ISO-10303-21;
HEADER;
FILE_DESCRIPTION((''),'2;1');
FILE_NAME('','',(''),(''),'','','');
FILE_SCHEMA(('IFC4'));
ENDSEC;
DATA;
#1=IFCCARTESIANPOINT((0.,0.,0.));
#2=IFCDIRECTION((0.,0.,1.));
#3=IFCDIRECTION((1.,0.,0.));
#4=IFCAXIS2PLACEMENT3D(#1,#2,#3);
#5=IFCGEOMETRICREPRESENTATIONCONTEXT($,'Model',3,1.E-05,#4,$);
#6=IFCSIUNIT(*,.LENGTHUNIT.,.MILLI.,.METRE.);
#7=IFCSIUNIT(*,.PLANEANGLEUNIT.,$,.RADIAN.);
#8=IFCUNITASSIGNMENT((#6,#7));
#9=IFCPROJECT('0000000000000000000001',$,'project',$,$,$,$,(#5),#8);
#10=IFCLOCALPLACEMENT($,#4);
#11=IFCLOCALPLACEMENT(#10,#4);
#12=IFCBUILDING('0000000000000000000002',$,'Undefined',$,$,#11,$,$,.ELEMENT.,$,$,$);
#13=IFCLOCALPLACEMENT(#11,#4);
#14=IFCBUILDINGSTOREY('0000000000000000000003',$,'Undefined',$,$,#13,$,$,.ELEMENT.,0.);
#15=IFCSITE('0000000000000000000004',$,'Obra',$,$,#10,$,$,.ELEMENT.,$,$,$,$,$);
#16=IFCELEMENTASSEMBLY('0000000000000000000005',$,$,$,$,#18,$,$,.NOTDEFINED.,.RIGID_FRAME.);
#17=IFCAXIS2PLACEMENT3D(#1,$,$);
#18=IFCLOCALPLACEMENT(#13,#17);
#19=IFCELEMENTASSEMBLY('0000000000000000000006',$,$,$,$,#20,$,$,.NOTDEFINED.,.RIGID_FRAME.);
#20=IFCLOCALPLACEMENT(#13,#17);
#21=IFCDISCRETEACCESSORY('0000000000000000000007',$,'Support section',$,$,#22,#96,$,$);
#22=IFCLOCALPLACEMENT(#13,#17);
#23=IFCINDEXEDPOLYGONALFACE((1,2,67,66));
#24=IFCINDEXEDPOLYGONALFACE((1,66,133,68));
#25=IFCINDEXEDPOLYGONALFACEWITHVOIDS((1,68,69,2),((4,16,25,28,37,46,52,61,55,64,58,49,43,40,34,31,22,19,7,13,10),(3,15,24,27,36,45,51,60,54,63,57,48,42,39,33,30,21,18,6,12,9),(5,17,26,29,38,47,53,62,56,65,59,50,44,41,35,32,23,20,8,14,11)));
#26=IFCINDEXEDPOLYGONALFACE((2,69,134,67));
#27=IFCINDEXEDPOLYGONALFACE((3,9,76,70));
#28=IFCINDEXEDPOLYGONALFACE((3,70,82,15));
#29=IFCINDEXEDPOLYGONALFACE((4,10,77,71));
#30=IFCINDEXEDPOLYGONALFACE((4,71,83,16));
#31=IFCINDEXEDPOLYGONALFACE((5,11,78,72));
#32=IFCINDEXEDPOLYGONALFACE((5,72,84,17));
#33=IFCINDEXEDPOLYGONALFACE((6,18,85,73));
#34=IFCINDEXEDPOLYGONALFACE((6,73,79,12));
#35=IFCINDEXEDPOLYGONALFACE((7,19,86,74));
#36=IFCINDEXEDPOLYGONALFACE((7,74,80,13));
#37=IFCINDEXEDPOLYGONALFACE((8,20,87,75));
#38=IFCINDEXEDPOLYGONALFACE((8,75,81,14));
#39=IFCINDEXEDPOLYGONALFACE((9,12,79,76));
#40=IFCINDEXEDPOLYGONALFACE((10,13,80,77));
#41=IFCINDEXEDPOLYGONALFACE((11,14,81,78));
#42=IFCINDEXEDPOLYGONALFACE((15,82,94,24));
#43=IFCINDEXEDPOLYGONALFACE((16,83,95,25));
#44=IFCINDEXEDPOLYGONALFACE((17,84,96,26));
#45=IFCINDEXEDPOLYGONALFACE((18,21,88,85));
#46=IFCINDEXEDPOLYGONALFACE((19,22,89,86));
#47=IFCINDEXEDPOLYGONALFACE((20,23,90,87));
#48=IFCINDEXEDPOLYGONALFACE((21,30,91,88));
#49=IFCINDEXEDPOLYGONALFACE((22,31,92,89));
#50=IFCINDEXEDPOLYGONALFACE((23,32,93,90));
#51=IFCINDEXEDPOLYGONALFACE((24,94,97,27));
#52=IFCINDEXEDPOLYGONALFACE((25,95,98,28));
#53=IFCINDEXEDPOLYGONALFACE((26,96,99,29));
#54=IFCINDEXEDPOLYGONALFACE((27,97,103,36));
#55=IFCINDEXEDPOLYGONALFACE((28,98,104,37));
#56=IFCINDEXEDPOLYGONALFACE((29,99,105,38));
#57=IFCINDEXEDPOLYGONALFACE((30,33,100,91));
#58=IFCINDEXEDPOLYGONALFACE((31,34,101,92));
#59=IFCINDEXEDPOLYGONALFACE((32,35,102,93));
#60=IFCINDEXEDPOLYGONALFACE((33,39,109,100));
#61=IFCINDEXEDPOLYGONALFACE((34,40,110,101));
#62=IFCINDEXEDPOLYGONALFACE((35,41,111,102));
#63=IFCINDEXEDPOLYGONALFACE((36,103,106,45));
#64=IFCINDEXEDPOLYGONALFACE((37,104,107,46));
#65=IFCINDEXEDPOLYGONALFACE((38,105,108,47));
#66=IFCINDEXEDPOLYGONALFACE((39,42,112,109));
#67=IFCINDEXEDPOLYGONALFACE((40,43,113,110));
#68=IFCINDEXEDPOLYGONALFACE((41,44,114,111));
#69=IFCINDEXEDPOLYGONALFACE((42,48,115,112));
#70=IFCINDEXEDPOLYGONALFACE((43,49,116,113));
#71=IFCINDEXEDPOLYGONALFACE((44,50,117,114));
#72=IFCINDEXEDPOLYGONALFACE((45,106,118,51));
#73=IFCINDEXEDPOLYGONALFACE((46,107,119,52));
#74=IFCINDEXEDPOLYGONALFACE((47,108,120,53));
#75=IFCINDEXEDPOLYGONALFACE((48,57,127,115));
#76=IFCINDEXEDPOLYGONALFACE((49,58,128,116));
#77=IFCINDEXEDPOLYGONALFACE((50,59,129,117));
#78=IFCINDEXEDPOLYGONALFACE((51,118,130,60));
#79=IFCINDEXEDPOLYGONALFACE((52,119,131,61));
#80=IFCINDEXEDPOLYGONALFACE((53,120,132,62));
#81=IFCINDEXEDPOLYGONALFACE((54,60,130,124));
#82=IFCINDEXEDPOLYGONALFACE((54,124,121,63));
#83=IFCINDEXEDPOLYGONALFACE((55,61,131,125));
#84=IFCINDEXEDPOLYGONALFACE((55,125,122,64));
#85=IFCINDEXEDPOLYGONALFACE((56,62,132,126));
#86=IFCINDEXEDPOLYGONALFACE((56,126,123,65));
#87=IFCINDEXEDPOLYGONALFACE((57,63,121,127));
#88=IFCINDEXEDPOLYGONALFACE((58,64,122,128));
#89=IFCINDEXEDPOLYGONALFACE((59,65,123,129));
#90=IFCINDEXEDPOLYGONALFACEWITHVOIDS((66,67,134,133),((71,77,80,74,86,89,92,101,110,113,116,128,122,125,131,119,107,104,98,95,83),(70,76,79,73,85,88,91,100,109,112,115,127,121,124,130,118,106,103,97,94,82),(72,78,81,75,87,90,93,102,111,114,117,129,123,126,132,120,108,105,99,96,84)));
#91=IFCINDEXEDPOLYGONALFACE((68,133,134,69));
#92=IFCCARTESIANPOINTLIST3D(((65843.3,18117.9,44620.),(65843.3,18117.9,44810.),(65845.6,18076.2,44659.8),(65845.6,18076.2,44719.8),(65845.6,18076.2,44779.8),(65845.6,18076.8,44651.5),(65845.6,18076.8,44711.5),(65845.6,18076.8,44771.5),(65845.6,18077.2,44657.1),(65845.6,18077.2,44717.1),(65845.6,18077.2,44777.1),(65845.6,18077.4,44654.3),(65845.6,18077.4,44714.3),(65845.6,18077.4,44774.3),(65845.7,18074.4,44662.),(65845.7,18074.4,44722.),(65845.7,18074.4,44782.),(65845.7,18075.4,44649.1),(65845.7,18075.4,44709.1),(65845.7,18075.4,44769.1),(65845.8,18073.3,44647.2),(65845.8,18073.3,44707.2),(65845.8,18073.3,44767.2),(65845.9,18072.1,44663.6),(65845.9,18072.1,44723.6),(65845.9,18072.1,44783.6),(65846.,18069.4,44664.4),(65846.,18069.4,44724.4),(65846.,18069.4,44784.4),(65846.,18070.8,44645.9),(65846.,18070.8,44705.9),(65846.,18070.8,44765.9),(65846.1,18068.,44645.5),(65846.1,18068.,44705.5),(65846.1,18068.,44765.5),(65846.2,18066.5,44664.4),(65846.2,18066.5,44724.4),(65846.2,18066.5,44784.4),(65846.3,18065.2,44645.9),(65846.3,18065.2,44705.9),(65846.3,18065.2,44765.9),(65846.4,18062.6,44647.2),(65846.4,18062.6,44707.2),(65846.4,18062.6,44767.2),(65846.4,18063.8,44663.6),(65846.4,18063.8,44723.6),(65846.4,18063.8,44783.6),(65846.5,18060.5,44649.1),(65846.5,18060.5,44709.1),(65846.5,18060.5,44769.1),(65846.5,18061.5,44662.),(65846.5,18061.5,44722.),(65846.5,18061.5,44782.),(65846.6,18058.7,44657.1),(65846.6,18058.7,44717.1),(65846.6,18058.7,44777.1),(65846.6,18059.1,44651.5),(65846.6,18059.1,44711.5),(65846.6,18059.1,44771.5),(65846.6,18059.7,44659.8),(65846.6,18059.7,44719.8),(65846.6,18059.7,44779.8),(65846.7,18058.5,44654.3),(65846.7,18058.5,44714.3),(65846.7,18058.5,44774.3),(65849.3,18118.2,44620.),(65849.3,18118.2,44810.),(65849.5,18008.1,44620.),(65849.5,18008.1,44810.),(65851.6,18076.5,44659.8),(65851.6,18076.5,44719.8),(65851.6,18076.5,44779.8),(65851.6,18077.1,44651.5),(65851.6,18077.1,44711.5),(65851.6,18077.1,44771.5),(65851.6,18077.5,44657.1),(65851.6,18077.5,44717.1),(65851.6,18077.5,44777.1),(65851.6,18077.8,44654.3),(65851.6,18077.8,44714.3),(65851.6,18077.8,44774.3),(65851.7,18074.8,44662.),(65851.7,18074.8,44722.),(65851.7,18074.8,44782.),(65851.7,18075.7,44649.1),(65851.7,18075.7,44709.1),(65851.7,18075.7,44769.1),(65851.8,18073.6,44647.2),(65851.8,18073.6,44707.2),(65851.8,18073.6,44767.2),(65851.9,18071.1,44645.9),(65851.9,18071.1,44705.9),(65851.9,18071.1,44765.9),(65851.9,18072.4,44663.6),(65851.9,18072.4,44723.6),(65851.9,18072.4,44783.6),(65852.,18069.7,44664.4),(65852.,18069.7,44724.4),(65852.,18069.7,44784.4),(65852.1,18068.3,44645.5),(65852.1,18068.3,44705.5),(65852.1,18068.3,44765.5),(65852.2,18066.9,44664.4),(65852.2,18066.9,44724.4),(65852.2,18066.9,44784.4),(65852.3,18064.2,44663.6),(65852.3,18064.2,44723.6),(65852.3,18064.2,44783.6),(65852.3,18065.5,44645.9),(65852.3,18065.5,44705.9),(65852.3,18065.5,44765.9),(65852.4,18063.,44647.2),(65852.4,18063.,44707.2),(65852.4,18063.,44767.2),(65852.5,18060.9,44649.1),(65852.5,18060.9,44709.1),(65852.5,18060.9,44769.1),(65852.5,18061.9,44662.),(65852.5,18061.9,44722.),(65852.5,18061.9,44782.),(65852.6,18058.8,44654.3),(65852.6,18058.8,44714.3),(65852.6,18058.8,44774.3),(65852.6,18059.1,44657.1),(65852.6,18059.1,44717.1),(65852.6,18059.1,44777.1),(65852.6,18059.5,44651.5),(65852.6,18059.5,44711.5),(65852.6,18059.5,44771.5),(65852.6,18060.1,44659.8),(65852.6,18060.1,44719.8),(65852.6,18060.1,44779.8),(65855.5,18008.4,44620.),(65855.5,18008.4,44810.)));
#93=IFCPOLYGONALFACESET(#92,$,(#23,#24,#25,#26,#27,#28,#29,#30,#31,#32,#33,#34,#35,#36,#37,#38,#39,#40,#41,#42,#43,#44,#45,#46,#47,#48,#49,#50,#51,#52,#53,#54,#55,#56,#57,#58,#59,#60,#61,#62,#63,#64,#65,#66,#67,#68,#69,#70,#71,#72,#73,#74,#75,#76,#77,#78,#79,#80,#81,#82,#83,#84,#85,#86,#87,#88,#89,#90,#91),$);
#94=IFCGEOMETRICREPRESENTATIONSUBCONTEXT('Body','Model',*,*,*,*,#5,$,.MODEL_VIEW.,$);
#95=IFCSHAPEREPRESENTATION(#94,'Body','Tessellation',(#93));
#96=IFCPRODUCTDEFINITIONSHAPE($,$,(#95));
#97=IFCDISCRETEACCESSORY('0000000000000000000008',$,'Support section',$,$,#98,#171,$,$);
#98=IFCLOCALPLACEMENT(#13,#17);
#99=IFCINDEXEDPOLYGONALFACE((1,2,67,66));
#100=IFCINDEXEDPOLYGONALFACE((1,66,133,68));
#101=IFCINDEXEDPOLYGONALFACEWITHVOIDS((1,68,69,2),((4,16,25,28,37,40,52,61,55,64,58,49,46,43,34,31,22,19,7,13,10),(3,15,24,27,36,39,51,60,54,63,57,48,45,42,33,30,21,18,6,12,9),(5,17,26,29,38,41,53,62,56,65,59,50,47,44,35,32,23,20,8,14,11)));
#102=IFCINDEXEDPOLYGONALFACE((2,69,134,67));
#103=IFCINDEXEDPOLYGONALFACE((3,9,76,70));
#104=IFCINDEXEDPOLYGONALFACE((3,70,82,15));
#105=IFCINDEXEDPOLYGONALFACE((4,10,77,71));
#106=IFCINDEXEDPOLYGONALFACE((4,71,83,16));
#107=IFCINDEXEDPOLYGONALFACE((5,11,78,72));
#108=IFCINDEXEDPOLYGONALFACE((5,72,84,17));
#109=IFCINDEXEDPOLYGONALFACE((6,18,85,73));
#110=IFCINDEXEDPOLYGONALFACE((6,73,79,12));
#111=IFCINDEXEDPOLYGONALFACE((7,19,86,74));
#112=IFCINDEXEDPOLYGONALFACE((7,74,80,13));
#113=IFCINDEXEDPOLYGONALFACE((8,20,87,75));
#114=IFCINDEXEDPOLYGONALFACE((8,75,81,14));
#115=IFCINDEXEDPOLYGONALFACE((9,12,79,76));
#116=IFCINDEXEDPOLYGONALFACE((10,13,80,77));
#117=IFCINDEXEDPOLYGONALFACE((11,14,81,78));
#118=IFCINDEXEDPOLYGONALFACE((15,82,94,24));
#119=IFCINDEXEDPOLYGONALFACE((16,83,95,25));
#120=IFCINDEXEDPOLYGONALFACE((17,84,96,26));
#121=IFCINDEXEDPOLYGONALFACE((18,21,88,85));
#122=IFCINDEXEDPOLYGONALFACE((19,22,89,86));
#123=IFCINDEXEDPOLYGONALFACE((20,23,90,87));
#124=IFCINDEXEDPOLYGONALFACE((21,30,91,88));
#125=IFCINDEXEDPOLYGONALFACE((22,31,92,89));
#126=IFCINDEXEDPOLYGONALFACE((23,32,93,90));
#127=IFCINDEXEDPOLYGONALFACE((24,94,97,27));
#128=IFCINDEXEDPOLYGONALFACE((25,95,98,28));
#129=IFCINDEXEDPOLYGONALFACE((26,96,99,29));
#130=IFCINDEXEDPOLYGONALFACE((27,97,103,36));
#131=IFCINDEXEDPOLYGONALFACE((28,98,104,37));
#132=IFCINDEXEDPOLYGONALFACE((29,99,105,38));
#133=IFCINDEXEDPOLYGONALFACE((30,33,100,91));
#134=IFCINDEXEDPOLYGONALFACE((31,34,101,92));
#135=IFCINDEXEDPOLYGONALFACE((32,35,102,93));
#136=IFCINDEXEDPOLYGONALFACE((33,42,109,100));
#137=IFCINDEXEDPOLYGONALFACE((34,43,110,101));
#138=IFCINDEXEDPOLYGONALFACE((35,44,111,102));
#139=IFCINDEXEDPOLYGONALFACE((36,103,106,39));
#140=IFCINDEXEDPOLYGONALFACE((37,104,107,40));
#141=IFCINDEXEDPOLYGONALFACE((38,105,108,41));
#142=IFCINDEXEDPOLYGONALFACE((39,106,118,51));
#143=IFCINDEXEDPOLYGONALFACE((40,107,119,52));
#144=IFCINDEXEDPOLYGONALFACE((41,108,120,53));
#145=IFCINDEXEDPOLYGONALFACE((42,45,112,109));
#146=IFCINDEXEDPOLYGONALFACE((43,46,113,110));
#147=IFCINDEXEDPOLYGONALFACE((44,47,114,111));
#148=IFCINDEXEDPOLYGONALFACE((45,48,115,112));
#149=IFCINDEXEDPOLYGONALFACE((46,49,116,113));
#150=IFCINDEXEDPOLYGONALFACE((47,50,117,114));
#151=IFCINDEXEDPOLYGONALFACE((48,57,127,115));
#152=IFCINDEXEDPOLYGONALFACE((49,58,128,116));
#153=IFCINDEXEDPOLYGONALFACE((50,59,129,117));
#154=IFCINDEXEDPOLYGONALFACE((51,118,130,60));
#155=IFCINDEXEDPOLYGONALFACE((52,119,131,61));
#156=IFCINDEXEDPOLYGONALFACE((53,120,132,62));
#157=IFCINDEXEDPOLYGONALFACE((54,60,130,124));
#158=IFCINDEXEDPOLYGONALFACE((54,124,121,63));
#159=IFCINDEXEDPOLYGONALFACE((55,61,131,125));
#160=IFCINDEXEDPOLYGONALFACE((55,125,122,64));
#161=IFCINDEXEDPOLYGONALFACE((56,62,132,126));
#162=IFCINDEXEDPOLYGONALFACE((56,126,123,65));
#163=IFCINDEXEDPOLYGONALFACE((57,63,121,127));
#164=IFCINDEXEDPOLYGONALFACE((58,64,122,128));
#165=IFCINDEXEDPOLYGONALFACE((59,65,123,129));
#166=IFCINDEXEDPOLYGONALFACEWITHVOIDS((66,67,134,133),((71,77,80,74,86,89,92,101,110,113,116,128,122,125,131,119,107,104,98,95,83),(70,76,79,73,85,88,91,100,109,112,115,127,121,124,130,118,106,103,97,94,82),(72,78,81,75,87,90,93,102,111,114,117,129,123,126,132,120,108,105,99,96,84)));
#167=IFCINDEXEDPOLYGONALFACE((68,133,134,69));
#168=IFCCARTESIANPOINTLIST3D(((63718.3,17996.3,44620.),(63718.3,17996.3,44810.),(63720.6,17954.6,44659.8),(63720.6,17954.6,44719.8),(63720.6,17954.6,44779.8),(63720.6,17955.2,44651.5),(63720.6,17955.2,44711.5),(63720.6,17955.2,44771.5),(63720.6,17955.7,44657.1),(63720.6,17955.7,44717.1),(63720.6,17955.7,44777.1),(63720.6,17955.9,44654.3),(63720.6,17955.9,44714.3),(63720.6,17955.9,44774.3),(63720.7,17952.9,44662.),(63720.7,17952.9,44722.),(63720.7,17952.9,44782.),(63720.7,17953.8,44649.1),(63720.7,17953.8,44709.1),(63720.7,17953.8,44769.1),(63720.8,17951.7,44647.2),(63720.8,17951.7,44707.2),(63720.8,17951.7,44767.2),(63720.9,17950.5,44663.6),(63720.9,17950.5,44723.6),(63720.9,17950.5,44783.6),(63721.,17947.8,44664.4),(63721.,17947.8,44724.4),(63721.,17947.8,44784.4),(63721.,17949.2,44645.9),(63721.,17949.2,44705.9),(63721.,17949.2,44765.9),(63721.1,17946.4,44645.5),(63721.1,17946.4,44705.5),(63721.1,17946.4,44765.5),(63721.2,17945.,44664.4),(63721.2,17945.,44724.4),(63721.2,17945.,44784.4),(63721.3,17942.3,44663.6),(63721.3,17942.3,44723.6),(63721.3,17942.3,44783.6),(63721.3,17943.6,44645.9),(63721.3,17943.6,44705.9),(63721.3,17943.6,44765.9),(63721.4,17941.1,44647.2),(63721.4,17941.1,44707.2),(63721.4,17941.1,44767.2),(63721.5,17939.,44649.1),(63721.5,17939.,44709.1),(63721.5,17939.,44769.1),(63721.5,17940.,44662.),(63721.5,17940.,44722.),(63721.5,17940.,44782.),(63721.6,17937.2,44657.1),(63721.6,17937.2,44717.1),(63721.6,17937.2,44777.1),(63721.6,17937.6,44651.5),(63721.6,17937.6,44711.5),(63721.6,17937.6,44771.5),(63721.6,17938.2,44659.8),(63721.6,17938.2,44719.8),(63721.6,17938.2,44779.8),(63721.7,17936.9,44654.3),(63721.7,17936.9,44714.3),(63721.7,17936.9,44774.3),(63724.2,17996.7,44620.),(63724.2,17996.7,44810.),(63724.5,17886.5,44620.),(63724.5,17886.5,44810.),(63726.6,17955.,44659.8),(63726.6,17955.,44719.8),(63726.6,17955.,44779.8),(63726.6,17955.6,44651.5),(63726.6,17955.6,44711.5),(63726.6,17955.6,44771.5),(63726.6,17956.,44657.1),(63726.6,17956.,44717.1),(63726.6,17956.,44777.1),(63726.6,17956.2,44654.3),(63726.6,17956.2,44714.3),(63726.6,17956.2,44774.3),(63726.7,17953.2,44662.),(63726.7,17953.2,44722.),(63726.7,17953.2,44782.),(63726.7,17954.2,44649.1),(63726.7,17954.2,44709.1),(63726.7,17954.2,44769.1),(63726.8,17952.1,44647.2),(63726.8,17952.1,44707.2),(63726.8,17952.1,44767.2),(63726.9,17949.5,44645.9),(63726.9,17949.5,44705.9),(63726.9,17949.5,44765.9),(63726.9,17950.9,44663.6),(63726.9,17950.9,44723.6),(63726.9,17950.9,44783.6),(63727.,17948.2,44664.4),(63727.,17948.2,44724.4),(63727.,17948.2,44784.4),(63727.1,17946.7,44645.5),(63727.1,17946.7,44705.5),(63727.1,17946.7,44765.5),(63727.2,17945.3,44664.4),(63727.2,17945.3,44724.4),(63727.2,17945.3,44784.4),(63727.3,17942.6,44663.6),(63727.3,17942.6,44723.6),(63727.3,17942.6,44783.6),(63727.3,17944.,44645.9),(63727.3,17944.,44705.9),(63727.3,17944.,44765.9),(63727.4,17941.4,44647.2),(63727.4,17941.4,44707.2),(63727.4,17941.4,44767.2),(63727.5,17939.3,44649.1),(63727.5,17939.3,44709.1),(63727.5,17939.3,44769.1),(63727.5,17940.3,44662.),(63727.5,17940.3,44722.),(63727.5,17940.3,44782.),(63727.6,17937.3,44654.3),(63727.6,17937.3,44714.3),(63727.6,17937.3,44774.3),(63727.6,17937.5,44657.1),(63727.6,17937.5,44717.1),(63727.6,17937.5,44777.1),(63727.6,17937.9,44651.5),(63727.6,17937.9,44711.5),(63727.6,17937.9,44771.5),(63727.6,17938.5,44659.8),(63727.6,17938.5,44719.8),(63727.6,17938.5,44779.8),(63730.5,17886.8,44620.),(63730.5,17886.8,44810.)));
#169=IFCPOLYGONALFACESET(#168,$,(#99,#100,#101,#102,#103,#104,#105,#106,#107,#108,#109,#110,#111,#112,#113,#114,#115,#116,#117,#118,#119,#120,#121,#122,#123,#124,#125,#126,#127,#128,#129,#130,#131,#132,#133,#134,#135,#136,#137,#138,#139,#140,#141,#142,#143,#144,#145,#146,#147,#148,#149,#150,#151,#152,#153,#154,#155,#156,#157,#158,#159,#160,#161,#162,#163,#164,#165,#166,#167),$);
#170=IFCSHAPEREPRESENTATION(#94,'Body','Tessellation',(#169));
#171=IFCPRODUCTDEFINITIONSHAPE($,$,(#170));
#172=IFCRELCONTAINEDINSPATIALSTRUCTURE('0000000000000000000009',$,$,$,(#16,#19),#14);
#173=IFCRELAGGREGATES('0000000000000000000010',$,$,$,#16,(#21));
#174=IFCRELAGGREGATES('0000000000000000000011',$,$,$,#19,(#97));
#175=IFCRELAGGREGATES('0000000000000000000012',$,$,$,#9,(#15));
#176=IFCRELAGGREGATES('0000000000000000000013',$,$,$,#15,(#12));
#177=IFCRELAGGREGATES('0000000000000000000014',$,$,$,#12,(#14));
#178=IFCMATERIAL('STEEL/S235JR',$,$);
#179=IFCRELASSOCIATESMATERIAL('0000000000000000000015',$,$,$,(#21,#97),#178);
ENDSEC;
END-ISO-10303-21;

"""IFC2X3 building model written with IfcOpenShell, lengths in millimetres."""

from ifc_helpers import new_model, si_unit, frame, origin_with_axes, origin_2d_with_axis, place, context, subcontext, project, spatial, rectangle, circle, extrude, source, transform, mapped, material, element, aggregate, save


model = new_model("IFC2X3")

# Units and contexts
model_context = context("Model", 3, precision=1e-05, world=origin_with_axes())
body_context = subcontext(model_context, "Body", "Model", "MODEL_VIEW")
ifc_project = project(units=[si_unit("LENGTHUNIT", "METRE", prefix="MILLI"), si_unit("PLANEANGLEUNIT", "RADIAN")], contexts=[model_context])

# Site, building, storey
site_placement = place(None, origin_with_axes())
site = spatial("IfcSite", under=ifc_project, at=site_placement, Name="Obra", CompositionType="ELEMENT")
building_placement = place(site_placement, origin_with_axes())
building = spatial("IfcBuilding", under=site, at=building_placement, Name="Undefined", CompositionType="ELEMENT")
storey_placement = place(building_placement, origin_with_axes())
storey = spatial("IfcBuildingStorey", under=building, at=storey_placement, Name="Undefined", CompositionType="ELEMENT", Elevation=0.0)

# Element assemblies
assembly_1_placement = place(storey_placement, origin_with_axes())
assembly_1 = element("IfcElementAssembly", 1, at=assembly_1_placement, inside=storey, AssemblyPlace="NOTDEFINED", PredefinedType="RIGID_FRAME")
ifc_material_1 = material(Name="STEEL/S235JR")
assembly_2_placement = place(storey_placement, origin_with_axes())
assembly_2 = element("IfcElementAssembly", 2, at=assembly_2_placement, inside=storey, AssemblyPlace="NOTDEFINED", PredefinedType="RIGID_FRAME")

# Discrete accessories, openings
discrete_accessory_1_placement = place(assembly_1_placement, frame((65849.4, 18063.1, 44620.0), z_axis=(0.0, 0.0, 1.0), x_axis=(0.057107, -0.998368, 0.0)))
discrete_accessory_1 = element("IfcDiscreteAccessory", 3, at=discrete_accessory_1_placement, material=ifc_material_1, Name="Support section", context=body_context, shape_type="SweptSolid", body=[
    extrude(rectangle(XDim=6.0, YDim=110.0, at=origin_2d_with_axis()), frame((0.0, 0.0, 190.0), z_axis=(0.0, 0.0, -1.0), x_axis=(0.0, 1.0, 0.0)), (0.0, 0.0, 1.0), 190.0),
])
shared_shape_1 = source(origin_with_axes(), body_context, "Body", "SweptSolid", [
    extrude(circle(Radius=9.5, at=origin_2d_with_axis()), frame((0.0, -9.2, 0.0), z_axis=(0.0, 1.0, 0.0), x_axis=(1.0, 0.0, 0.0)), (0.0, 0.0, 1.0), 6.2),
])
opening_1_placement = place(assembly_1_placement, frame((65845.9, 18017.9, 44835.0), z_axis=(-0.057107, 0.998368, 0.0), x_axis=(0.0, 0.0, -1.0)))
element("IfcOpeningElement", 4, at=opening_1_placement, cuts=discrete_accessory_1, ObjectType="Opening", context=body_context, shape_type="MappedRepresentation", body=[
    mapped(shared_shape_1, transform((60.0, 0.0, 50.0))),
    mapped(shared_shape_1, transform((120.0, 0.0, 50.0))),
    mapped(shared_shape_1, transform((180.0, 0.0, 50.0))),
])
aggregate(assembly_1, [discrete_accessory_1])
discrete_accessory_2_placement = place(assembly_2_placement, frame((63724.4, 17941.6, 44620.0), z_axis=(0.0, 0.0, 1.0), x_axis=(0.057107, -0.998368, 0.0)))
discrete_accessory_2 = element("IfcDiscreteAccessory", 5, at=discrete_accessory_2_placement, material=ifc_material_1, Name="Support section", context=body_context, shape_type="SweptSolid", body=[
    extrude(rectangle(XDim=6.0, YDim=110.0, at=origin_2d_with_axis()), frame((0.0, 0.0, 190.0), z_axis=(0.0, 0.0, -1.0), x_axis=(0.0, 1.0, 0.0)), (0.0, 0.0, 1.0), 190.0),
])
opening_2_placement = place(assembly_2_placement, frame((63720.9, 17896.3, 44835.0), z_axis=(-0.057107, 0.998368, 0.0), x_axis=(0.0, 0.0, -1.0)))
element("IfcOpeningElement", 6, at=opening_2_placement, cuts=discrete_accessory_2, ObjectType="Opening", context=body_context, shape_type="MappedRepresentation", body=[
    mapped(shared_shape_1, transform((60.0, 0.0, 50.0))),
    mapped(shared_shape_1, transform((120.0, 0.0, 50.0))),
    mapped(shared_shape_1, transform((180.0, 0.0, 50.0))),
])
aggregate(assembly_2, [discrete_accessory_2])

save(model, "model.ifc")
